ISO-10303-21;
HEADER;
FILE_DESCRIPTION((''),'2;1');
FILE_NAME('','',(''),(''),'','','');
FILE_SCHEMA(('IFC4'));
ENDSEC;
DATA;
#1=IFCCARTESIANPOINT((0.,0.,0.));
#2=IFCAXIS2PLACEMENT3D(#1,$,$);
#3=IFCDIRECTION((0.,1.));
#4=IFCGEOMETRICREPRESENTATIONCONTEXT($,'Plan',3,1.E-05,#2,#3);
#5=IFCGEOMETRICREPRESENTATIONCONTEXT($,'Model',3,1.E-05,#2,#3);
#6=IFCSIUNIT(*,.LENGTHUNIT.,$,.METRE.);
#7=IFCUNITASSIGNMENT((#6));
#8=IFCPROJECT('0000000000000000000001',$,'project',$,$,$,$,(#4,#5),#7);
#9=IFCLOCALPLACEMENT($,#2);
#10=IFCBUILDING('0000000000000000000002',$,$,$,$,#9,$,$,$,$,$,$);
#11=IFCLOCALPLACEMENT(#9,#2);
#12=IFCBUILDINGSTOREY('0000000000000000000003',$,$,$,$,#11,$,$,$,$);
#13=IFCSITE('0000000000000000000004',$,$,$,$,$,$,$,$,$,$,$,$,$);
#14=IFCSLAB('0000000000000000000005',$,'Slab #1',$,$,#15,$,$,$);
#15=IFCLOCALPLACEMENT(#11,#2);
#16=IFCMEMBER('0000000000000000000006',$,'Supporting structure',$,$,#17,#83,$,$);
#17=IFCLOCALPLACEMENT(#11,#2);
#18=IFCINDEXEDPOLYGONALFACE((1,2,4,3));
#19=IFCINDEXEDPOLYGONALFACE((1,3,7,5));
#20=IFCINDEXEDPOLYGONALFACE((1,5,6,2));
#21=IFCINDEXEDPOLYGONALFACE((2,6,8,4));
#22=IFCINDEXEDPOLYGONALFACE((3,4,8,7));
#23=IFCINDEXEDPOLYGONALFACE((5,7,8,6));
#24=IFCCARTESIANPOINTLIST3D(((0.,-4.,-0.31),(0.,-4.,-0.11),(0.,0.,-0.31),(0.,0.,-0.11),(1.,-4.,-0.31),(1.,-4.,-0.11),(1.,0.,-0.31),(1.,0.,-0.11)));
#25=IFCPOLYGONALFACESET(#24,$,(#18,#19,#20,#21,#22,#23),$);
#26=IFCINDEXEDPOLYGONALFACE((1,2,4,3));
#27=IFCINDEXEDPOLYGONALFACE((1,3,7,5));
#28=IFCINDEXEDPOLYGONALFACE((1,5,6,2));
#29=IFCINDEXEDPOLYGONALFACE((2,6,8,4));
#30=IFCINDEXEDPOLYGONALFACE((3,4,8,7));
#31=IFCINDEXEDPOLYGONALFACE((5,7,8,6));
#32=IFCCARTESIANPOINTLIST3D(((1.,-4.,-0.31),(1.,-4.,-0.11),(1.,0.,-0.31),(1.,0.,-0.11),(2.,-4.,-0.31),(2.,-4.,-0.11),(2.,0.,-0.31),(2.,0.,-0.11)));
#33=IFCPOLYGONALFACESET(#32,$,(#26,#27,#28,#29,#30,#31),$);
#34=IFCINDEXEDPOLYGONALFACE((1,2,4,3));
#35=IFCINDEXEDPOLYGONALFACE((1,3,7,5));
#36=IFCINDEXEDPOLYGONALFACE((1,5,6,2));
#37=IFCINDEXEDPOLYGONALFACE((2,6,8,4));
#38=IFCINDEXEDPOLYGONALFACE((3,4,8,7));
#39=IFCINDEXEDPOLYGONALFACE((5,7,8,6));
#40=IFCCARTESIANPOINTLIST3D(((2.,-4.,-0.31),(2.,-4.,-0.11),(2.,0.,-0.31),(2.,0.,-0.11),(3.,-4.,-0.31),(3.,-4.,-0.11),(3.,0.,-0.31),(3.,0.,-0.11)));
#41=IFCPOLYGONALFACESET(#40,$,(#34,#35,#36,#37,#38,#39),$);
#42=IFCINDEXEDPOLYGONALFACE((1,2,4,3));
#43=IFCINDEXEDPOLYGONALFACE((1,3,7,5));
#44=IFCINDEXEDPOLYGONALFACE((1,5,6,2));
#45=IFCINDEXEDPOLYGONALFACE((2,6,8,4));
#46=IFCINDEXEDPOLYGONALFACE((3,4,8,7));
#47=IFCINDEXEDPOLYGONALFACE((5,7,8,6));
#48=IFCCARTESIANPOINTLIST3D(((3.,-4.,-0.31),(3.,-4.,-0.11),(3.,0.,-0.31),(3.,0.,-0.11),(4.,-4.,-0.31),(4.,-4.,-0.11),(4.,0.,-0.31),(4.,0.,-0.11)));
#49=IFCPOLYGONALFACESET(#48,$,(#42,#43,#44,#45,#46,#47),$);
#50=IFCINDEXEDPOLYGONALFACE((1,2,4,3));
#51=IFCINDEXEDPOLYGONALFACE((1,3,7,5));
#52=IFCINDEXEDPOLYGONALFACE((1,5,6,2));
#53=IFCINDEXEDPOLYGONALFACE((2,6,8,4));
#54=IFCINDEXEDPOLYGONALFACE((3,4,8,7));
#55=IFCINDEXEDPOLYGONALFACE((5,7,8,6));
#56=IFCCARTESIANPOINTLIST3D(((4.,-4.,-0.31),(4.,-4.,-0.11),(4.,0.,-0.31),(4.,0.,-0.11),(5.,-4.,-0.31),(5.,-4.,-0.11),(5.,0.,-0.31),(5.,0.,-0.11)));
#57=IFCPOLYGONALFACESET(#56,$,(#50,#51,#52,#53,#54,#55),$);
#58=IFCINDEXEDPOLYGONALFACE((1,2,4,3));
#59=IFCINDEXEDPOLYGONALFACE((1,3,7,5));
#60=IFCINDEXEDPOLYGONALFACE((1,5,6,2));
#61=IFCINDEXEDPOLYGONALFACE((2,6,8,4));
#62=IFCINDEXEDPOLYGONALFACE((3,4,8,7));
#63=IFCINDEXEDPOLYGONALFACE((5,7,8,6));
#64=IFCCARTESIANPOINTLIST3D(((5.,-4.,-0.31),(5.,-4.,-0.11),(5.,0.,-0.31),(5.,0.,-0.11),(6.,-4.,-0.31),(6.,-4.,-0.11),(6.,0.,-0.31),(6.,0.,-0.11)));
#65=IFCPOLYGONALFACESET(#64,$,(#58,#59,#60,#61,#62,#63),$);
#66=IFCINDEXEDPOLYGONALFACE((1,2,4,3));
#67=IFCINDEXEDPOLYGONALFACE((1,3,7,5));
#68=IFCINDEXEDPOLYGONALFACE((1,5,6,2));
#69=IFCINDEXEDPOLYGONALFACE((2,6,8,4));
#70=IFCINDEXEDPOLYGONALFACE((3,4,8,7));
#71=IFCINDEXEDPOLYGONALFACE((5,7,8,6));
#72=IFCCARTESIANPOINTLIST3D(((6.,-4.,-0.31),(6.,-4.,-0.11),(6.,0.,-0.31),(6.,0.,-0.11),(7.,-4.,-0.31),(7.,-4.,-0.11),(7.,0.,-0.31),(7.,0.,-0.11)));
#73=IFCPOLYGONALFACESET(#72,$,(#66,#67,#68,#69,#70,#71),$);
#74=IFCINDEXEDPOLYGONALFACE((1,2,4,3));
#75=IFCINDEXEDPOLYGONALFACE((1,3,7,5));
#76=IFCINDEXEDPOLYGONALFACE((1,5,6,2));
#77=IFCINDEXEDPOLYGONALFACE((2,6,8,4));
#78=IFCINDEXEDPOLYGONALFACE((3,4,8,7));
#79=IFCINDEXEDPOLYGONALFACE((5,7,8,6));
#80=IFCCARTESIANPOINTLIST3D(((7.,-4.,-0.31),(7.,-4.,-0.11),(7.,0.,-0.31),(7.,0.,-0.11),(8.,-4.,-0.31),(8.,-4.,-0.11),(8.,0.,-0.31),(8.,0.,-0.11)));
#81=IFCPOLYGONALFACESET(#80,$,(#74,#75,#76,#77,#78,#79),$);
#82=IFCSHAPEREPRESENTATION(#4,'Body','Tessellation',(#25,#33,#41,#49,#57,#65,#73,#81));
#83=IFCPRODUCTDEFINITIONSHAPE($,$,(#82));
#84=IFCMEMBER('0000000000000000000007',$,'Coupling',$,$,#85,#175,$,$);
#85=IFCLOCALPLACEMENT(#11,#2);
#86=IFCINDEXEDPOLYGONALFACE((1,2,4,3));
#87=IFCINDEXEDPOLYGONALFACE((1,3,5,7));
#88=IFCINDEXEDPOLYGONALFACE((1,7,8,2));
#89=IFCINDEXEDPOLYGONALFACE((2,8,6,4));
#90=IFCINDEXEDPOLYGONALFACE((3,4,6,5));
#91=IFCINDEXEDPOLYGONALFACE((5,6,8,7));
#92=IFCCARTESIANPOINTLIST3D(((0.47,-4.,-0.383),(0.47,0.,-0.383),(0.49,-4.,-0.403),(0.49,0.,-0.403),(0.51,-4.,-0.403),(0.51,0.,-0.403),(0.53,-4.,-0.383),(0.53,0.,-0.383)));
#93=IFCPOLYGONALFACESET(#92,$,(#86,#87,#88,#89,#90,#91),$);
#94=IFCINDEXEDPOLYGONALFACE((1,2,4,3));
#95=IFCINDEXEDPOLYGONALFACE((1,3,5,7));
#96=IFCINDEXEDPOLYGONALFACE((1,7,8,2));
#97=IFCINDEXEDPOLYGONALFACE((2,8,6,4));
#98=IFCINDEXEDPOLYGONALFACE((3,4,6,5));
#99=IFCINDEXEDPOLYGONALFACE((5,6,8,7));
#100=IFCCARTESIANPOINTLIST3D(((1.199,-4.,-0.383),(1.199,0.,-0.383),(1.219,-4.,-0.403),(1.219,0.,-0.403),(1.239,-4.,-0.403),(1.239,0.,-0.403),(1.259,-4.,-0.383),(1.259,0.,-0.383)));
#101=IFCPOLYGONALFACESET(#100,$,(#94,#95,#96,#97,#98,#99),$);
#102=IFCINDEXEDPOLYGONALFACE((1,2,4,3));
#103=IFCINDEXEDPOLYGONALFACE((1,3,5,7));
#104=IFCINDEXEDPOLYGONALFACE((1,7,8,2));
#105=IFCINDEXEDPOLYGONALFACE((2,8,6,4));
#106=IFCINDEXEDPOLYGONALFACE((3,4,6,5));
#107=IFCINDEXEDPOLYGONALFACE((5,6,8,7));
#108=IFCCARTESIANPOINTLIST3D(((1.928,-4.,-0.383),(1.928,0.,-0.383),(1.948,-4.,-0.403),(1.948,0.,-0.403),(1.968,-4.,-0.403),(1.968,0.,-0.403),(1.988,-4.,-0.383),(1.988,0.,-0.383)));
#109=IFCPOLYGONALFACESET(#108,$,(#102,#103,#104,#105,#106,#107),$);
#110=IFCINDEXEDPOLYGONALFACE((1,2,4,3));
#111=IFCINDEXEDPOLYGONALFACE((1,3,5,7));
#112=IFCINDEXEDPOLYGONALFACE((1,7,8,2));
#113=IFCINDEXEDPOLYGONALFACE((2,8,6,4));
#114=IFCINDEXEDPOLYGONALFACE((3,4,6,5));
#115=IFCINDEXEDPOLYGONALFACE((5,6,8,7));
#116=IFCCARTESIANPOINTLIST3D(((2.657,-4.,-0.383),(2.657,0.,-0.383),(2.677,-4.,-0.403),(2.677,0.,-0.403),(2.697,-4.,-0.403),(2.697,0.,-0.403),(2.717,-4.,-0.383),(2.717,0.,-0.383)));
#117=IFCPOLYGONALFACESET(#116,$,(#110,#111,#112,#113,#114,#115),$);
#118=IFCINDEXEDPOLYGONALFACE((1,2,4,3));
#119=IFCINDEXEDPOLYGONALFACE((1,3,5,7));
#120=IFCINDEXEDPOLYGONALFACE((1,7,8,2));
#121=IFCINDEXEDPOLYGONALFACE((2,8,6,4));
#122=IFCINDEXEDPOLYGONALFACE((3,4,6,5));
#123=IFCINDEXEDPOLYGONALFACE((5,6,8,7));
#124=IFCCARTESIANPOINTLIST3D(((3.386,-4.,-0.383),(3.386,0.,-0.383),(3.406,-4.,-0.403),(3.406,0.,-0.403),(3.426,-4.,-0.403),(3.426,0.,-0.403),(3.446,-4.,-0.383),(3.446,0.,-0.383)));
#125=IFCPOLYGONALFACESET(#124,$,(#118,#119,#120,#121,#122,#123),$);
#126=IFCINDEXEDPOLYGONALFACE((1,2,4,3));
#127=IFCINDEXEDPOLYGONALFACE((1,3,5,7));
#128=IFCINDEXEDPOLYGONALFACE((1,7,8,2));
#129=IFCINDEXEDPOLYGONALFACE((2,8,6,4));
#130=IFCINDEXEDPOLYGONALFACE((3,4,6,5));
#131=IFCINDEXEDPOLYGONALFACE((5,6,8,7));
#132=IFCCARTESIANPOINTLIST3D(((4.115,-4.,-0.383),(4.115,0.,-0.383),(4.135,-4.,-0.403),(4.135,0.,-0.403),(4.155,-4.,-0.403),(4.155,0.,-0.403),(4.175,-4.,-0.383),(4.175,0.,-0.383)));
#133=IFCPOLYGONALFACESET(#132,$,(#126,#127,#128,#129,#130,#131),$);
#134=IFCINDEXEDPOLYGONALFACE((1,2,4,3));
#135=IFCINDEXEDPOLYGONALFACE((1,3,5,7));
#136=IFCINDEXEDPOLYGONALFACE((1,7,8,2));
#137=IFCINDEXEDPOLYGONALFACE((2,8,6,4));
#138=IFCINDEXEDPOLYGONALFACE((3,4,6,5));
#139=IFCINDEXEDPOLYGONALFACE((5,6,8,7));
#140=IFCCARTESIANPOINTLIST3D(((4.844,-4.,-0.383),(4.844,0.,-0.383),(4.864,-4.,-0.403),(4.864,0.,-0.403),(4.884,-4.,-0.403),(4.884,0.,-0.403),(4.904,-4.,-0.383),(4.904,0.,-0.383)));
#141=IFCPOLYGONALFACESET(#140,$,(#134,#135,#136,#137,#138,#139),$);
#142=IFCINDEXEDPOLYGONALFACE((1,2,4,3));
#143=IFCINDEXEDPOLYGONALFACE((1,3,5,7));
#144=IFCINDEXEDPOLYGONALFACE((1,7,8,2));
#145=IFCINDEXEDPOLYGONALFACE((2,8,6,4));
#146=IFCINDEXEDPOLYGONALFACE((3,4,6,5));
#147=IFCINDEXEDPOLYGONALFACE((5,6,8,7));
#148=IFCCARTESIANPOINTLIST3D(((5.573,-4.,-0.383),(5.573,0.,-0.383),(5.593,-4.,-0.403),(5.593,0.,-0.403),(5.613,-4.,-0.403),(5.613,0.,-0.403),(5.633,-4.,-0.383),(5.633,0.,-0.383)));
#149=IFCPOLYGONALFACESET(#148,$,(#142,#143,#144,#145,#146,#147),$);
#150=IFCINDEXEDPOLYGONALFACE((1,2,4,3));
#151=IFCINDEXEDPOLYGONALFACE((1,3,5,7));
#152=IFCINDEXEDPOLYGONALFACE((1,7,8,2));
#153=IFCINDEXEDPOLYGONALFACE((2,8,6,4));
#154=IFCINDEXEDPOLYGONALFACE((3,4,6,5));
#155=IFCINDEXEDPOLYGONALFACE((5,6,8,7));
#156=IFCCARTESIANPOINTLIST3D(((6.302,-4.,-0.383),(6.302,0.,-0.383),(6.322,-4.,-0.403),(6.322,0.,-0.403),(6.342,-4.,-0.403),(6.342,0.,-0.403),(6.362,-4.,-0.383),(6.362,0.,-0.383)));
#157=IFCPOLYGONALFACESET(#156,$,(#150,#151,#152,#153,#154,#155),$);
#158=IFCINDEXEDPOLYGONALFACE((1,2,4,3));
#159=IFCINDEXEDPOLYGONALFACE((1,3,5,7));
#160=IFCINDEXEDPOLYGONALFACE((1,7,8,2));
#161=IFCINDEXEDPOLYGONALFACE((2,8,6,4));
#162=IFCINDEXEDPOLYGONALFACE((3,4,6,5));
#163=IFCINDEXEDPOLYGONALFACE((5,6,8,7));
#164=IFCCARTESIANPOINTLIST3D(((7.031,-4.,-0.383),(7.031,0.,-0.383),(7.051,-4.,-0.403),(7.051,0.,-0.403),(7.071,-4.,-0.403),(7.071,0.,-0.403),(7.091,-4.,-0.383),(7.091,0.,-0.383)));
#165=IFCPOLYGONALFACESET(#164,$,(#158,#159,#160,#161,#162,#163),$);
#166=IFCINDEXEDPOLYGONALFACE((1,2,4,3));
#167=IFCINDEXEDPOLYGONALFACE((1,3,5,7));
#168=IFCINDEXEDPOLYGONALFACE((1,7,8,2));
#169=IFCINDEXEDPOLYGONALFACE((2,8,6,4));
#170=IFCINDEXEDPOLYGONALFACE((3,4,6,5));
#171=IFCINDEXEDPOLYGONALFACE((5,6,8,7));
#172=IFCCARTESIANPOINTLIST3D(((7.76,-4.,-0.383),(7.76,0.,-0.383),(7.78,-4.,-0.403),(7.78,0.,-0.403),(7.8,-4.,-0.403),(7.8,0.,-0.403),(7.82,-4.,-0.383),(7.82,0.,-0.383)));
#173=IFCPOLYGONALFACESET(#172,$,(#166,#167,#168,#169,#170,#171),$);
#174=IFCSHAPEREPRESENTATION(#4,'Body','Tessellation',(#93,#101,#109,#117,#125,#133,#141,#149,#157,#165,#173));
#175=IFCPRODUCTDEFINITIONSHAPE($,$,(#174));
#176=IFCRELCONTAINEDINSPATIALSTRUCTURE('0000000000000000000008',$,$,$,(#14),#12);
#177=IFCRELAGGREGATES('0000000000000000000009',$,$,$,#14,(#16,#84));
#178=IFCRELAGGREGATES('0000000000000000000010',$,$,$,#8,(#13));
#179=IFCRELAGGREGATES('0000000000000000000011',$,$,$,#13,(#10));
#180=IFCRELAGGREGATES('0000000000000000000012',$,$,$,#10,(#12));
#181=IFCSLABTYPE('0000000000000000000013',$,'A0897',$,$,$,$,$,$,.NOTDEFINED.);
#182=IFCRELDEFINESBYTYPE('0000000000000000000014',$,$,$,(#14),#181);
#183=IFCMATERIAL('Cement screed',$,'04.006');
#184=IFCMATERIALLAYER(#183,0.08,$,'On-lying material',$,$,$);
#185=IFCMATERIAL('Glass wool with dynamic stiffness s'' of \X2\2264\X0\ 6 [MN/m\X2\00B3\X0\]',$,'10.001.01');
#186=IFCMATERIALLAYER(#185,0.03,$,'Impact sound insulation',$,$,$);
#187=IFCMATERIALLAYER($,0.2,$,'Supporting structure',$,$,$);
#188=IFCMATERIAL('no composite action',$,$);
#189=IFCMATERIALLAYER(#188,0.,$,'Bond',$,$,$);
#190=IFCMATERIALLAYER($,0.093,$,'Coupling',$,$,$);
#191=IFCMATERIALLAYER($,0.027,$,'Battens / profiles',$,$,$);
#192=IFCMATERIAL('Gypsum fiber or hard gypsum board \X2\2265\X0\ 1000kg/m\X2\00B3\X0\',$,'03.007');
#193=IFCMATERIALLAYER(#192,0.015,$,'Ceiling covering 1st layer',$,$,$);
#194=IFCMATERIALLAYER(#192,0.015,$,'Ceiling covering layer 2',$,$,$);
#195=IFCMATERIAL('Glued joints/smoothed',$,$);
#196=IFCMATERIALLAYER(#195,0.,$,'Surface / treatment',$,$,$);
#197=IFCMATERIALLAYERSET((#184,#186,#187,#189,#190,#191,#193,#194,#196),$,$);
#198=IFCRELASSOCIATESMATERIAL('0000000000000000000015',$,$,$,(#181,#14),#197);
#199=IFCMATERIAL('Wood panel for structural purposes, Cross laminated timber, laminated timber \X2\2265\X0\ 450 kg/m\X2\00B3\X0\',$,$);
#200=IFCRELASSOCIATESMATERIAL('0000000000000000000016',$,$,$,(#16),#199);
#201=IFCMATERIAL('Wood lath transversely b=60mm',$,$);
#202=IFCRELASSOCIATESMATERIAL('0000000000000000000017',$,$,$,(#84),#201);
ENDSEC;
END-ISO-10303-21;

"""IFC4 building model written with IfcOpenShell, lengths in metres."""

from ifc_helpers import new_model, si_unit, direction, frame, frame_2d, origin, place, context, project, spatial, polyline, rectangle, outline, extrude, material, layer, layer_set, type_object, element, aggregate, save


model = new_model("IFC4")

# Units and contexts
plan_context = context("Plan", 3, precision=1e-05, world=origin(), true_north=direction((0.0, 1.0)))
model_context = context("Model", 3, precision=1e-05, world=origin(), true_north=direction((0.0, 1.0)))
ifc_project = project(units=[si_unit("LENGTHUNIT", "METRE")], contexts=[plan_context, model_context])

# Site, building, storey
site = spatial("IfcSite", under=ifc_project)
building_placement = place(None, origin())
building = spatial("IfcBuilding", under=site, at=building_placement)
storey_placement = place(building_placement, origin())
storey = spatial("IfcBuildingStorey", under=building, at=storey_placement)

# Slab, members
ifc_material_1 = material(Name="Cement screed", Category="04.006")
ifc_layer_1 = layer(ifc_material_1, 0.08, Name="On-lying material")
ifc_material_2 = material(Name="Glass wool with dynamic stiffness s' of ≤ 6 [MN/m³]", Category="10.001.01")
ifc_layer_2 = layer(ifc_material_2, 0.03, Name="Impact sound insulation")
ifc_layer_3 = layer(None, 0.2, Name="Supporting structure")
ifc_material_3 = material(Name="no composite action")
ifc_layer_4 = layer(ifc_material_3, 0.0, Name="Bond")
ifc_layer_5 = layer(None, 0.093, Name="Coupling")
ifc_layer_6 = layer(None, 0.027, Name="Battens / profiles")
ifc_material_4 = material(Name="Gypsum fiber or hard gypsum board ≥ 1000kg/m³", Category="03.007")
ifc_layer_7 = layer(ifc_material_4, 0.015, Name="Ceiling covering 1st layer")
ifc_layer_8 = layer(ifc_material_4, 0.015, Name="Ceiling covering layer 2")
ifc_material_5 = material(Name="Glued joints/smoothed")
ifc_layer_9 = layer(ifc_material_5, 0.0, Name="Surface / treatment")
ifc_layer_set = layer_set([ifc_layer_1, ifc_layer_2, ifc_layer_3, ifc_layer_4, ifc_layer_5, ifc_layer_6, ifc_layer_7, ifc_layer_8, ifc_layer_9])
slab_type = type_object("IfcSlabType", Name="A0897", PredefinedType="NOTDEFINED", material=ifc_layer_set)
slab_placement = place(None, frame((0.0, 0.0, 0.0), z_axis=(0.0, 0.0, -1.0), x_axis=(1.0, 0.0, 0.0)))
slab = element("IfcSlab", 1, at=slab_placement, inside=storey, type_object=slab_type, material=ifc_layer_set, Name="Slab #1")
ifc_material_6 = material(Name="Wood panel for structural purposes, Cross laminated timber, laminated timber ≥ 450 kg/m³")
member_1_placement = place(slab_placement, origin())
member_1 = element("IfcMember", 2, at=member_1_placement, material=ifc_material_6, Name="Supporting structure", context=plan_context, shape_type="SweptSolid", body=[
    extrude(rectangle(XDim=1.0, YDim=0.2, at=frame_2d((0.5, 0.1), x_axis=(1.0, 0.0))), frame((0.0, 4.0, 0.11), z_axis=(0.0, -1.0, 0.0), x_axis=(1.0, 0.0, 0.0)), (0.0, 0.0, 1.0), 4.0),
    extrude(rectangle(XDim=1.0, YDim=0.2, at=frame_2d((0.5, 0.1), x_axis=(1.0, 0.0))), frame((1.0, 4.0, 0.11), z_axis=(0.0, -1.0, 0.0), x_axis=(1.0, 0.0, 0.0)), (0.0, 0.0, 1.0), 4.0),
    extrude(rectangle(XDim=1.0, YDim=0.2, at=frame_2d((0.5, 0.1), x_axis=(1.0, 0.0))), frame((2.0, 4.0, 0.11), z_axis=(0.0, -1.0, 0.0), x_axis=(1.0, 0.0, 0.0)), (0.0, 0.0, 1.0), 4.0),
    extrude(rectangle(XDim=1.0, YDim=0.2, at=frame_2d((0.5, 0.1), x_axis=(1.0, 0.0))), frame((3.0, 4.0, 0.11), z_axis=(0.0, -1.0, 0.0), x_axis=(1.0, 0.0, 0.0)), (0.0, 0.0, 1.0), 4.0),
    extrude(rectangle(XDim=1.0, YDim=0.2, at=frame_2d((0.5, 0.1), x_axis=(1.0, 0.0))), frame((4.0, 4.0, 0.11), z_axis=(0.0, -1.0, 0.0), x_axis=(1.0, 0.0, 0.0)), (0.0, 0.0, 1.0), 4.0),
    extrude(rectangle(XDim=1.0, YDim=0.2, at=frame_2d((0.5, 0.1), x_axis=(1.0, 0.0))), frame((5.0, 4.0, 0.11), z_axis=(0.0, -1.0, 0.0), x_axis=(1.0, 0.0, 0.0)), (0.0, 0.0, 1.0), 4.0),
    extrude(rectangle(XDim=1.0, YDim=0.2, at=frame_2d((0.5, 0.1), x_axis=(1.0, 0.0))), frame((6.0, 4.0, 0.11), z_axis=(0.0, -1.0, 0.0), x_axis=(1.0, 0.0, 0.0)), (0.0, 0.0, 1.0), 4.0),
    extrude(rectangle(XDim=1.0, YDim=0.2, at=frame_2d((0.5, 0.1), x_axis=(1.0, 0.0))), frame((7.0, 4.0, 0.11), z_axis=(0.0, -1.0, 0.0), x_axis=(1.0, 0.0, 0.0)), (0.0, 0.0, 1.0), 4.0),
])
ifc_material_7 = material(Name="Wood lath transversely b=60mm")
member_2_placement = place(slab_placement, origin())
member_2 = element("IfcMember", 3, at=member_2_placement, material=ifc_material_7, Name="Coupling", context=plan_context, shape_type="SweptSolid", body=[
    extrude(outline(polyline([(0.0, 0.0), (0.06, 0.0), (0.04, 0.02), (0.02, 0.02), (0.0, 0.0)])), frame((0.47, 4.0, 0.383), z_axis=(0.0, -1.0, 0.0), x_axis=(1.0, 0.0, 0.0)), (0.0, 0.0, 1.0), 4.0),
    extrude(outline(polyline([(0.0, 0.0), (0.06, 0.0), (0.04, 0.02), (0.02, 0.02), (0.0, 0.0)])), frame((1.199, 4.0, 0.383), z_axis=(0.0, -1.0, 0.0), x_axis=(1.0, 0.0, 0.0)), (0.0, 0.0, 1.0), 4.0),
    extrude(outline(polyline([(0.0, 0.0), (0.06, 0.0), (0.04, 0.02), (0.02, 0.02), (0.0, 0.0)])), frame((1.928, 4.0, 0.383), z_axis=(0.0, -1.0, 0.0), x_axis=(1.0, 0.0, 0.0)), (0.0, 0.0, 1.0), 4.0),
    extrude(outline(polyline([(0.0, 0.0), (0.06, 0.0), (0.04, 0.02), (0.02, 0.02), (0.0, 0.0)])), frame((2.657, 4.0, 0.383), z_axis=(0.0, -1.0, 0.0), x_axis=(1.0, 0.0, 0.0)), (0.0, 0.0, 1.0), 4.0),
    extrude(outline(polyline([(0.0, 0.0), (0.06, 0.0), (0.04, 0.02), (0.02, 0.02), (0.0, 0.0)])), frame((3.386, 4.0, 0.383), z_axis=(0.0, -1.0, 0.0), x_axis=(1.0, 0.0, 0.0)), (0.0, 0.0, 1.0), 4.0),
    extrude(outline(polyline([(0.0, 0.0), (0.06, 0.0), (0.04, 0.02), (0.02, 0.02), (0.0, 0.0)])), frame((4.115, 4.0, 0.383), z_axis=(0.0, -1.0, 0.0), x_axis=(1.0, 0.0, 0.0)), (0.0, 0.0, 1.0), 4.0),
    extrude(outline(polyline([(0.0, 0.0), (0.06, 0.0), (0.04, 0.02), (0.02, 0.02), (0.0, 0.0)])), frame((4.844, 4.0, 0.383), z_axis=(0.0, -1.0, 0.0), x_axis=(1.0, 0.0, 0.0)), (0.0, 0.0, 1.0), 4.0),
    extrude(outline(polyline([(0.0, 0.0), (0.06, 0.0), (0.04, 0.02), (0.02, 0.02), (0.0, 0.0)])), frame((5.573, 4.0, 0.383), z_axis=(0.0, -1.0, 0.0), x_axis=(1.0, 0.0, 0.0)), (0.0, 0.0, 1.0), 4.0),
    extrude(outline(polyline([(0.0, 0.0), (0.06, 0.0), (0.04, 0.02), (0.02, 0.02), (0.0, 0.0)])), frame((6.302, 4.0, 0.383), z_axis=(0.0, -1.0, 0.0), x_axis=(1.0, 0.0, 0.0)), (0.0, 0.0, 1.0), 4.0),
    extrude(outline(polyline([(0.0, 0.0), (0.06, 0.0), (0.04, 0.02), (0.02, 0.02), (0.0, 0.0)])), frame((7.031, 4.0, 0.383), z_axis=(0.0, -1.0, 0.0), x_axis=(1.0, 0.0, 0.0)), (0.0, 0.0, 1.0), 4.0),
    extrude(outline(polyline([(0.0, 0.0), (0.06, 0.0), (0.04, 0.02), (0.02, 0.02), (0.0, 0.0)])), frame((7.76, 4.0, 0.383), z_axis=(0.0, -1.0, 0.0), x_axis=(1.0, 0.0, 0.0)), (0.0, 0.0, 1.0), 4.0),
])
aggregate(slab, [member_1, member_2])

save(model, "model.ifc")
